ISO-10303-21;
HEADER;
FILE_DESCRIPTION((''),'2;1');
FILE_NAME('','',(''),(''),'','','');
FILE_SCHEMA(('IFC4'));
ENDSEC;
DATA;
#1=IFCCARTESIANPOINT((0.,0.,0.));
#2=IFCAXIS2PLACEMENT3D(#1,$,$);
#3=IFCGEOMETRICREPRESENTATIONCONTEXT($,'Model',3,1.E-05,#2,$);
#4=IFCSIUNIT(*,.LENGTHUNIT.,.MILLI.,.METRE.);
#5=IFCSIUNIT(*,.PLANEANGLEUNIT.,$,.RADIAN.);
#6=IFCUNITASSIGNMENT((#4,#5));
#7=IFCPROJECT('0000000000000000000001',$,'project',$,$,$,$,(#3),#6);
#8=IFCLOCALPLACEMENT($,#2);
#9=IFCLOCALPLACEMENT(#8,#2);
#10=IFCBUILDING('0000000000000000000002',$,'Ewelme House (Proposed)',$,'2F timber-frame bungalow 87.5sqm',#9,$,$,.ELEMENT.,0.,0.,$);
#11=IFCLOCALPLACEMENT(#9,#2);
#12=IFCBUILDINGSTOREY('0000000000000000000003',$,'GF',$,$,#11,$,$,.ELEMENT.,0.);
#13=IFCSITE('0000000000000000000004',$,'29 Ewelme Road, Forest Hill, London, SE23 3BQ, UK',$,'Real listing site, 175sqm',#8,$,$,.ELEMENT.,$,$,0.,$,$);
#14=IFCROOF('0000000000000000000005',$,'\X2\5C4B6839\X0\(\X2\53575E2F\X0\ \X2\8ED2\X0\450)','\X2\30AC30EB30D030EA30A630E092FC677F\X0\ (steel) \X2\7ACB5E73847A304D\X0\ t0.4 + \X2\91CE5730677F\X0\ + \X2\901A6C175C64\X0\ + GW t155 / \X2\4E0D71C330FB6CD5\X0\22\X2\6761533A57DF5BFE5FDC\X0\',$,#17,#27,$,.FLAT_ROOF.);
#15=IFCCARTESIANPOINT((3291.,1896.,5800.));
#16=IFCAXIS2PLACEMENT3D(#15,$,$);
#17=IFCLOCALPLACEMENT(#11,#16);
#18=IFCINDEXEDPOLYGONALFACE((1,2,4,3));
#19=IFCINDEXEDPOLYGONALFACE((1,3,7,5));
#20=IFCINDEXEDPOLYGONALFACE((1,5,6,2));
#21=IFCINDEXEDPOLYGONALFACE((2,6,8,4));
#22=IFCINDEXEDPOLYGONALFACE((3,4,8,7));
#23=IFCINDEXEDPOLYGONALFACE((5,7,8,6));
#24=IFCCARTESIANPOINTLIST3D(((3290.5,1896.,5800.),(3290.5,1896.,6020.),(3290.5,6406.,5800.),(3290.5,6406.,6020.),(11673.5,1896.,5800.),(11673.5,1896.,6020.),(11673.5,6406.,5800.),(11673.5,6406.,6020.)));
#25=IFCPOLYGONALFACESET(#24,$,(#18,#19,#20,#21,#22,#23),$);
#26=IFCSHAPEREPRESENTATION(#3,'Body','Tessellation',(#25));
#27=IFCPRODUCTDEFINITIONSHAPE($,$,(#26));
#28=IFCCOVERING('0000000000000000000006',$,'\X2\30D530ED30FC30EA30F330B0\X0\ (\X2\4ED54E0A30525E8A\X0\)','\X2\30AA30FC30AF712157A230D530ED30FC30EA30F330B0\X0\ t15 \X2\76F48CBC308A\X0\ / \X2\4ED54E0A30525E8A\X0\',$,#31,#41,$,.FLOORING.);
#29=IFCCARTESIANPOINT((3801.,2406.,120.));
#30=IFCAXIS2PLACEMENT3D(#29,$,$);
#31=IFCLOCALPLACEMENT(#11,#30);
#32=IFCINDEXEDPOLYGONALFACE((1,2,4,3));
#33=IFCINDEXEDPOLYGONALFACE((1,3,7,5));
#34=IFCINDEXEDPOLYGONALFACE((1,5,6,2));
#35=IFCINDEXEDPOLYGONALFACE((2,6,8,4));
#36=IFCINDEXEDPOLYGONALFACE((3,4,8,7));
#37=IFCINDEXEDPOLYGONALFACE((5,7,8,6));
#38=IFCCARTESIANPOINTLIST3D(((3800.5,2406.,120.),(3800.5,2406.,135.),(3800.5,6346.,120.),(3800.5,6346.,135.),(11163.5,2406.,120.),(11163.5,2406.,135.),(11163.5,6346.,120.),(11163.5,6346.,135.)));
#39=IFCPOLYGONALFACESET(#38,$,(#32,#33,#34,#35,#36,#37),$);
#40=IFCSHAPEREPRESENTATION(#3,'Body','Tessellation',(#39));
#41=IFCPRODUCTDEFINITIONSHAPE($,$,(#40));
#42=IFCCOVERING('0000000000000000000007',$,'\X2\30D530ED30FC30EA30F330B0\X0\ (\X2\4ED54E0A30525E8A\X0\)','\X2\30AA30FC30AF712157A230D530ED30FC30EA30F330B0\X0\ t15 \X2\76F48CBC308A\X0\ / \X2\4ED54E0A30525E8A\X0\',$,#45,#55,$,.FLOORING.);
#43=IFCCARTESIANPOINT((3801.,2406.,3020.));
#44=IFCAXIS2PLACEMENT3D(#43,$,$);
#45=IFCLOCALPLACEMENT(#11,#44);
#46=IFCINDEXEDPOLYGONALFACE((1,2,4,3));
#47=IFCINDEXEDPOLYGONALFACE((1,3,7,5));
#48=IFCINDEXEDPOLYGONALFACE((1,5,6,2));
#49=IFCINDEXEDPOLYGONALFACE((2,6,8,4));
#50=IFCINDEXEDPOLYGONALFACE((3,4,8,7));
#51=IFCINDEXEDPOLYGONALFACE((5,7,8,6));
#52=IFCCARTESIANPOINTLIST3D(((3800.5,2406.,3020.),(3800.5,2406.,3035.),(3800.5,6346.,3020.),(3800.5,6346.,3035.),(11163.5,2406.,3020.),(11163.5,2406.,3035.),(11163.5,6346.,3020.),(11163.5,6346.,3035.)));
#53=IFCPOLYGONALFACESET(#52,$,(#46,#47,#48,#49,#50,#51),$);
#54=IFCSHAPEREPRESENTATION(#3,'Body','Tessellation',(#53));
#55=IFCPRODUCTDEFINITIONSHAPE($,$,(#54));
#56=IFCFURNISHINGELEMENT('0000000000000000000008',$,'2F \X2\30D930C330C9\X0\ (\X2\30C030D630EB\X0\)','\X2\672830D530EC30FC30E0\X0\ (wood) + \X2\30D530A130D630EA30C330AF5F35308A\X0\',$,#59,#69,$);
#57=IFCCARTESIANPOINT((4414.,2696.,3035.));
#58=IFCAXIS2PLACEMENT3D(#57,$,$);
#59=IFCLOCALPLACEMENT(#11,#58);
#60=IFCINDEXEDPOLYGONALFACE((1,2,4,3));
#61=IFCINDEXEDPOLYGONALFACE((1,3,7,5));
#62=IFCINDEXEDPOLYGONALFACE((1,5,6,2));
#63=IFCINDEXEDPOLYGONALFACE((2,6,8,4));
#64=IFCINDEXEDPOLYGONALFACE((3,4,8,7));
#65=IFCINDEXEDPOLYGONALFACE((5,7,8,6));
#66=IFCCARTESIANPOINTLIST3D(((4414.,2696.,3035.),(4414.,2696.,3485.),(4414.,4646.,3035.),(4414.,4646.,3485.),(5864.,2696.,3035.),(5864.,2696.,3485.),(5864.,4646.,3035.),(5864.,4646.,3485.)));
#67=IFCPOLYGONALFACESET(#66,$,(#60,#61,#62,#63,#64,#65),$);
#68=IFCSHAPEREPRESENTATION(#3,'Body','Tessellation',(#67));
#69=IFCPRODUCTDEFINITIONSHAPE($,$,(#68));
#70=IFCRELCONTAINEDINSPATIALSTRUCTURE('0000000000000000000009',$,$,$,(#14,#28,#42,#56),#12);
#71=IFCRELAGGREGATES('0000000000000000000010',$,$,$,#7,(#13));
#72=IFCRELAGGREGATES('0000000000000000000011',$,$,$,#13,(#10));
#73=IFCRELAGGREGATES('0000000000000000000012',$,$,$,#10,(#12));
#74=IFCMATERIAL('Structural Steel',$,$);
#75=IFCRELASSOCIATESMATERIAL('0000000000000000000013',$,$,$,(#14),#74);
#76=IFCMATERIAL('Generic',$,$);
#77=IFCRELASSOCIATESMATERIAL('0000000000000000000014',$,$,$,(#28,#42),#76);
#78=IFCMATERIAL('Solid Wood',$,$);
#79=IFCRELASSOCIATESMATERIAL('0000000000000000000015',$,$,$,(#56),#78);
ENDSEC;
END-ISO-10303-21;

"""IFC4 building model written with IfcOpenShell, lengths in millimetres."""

from ifc_helpers import new_model, si_unit, frame, frame_2d, origin, place, context, project, spatial, rectangle, extrude, material, element, save


model = new_model("IFC4")

# Units and contexts
model_context = context("Model", 3, precision=1e-05, world=origin())
ifc_project = project(units=[si_unit("LENGTHUNIT", "METRE", prefix="MILLI"), si_unit("PLANEANGLEUNIT", "RADIAN")], contexts=[model_context])

# Site, building, storey
site_placement = place(None, origin())
site = spatial("IfcSite", under=ifc_project, at=site_placement, Name="29 Ewelme Road, Forest Hill, London, SE23 3BQ, UK", ObjectType="Real listing site, 175sqm", CompositionType="ELEMENT", RefElevation=0.0)
building_placement = place(site_placement, origin())
building = spatial("IfcBuilding", under=site, at=building_placement, Name="Ewelme House (Proposed)", ObjectType="2F timber-frame bungalow 87.5sqm", CompositionType="ELEMENT", ElevationOfRefHeight=0.0, ElevationOfTerrain=0.0)
storey_placement = place(building_placement, origin())
storey = spatial("IfcBuildingStorey", under=building, at=storey_placement, Name="GF", CompositionType="ELEMENT", Elevation=0.0)

# Shared definitions
ifc_material_1 = material(Name="Solid Wood")

# Roof
ifc_material_2 = material(Name="Structural Steel")
for number, where, name in (
    (1, (3291.0, 1896.0, 5800.0), "屋根(南帯 軒450)"),
):
    element("IfcRoof", number, at=place(storey_placement, frame(where)), inside=storey, material=ifc_material_2, Name=name, Description="ガルバリウム鋼板 (steel) 立平葺き t0.4 + 野地板 + 通気層 + GW t155 / 不燃・法22条区域対応", PredefinedType="FLAT_ROOF", context=model_context, shape_type="SweptSolid", body=[
        extrude(rectangle(XDim=8383.0, YDim=4510.0, at=frame_2d((4191.0, 2255.0))), frame((3291.0, 1896.0, 5800.0)), (0.0, 0.0, 1.0), 220.0),
    ])

# Coverings
ifc_material_3 = material(Name="Generic")
covering_1_placement = place(storey_placement, frame((3801.0, 2406.0, 120.0)))
element("IfcCovering", 2, at=covering_1_placement, inside=storey, material=ifc_material_3, Name="フローリング (仕上げ床)", Description="オーク無垢フローリング t15 直貼り / 仕上げ床", PredefinedType="FLOORING", context=model_context, shape_type="SweptSolid", body=[
    extrude(rectangle(XDim=7363.0, YDim=3940.0, at=frame_2d((3681.0, 1970.0))), frame((3801.0, 2406.0, 120.0)), (0.0, 0.0, 1.0), 15.0),
])
covering_2_placement = place(storey_placement, frame((3801.0, 2406.0, 3020.0)))
element("IfcCovering", 3, at=covering_2_placement, inside=storey, material=ifc_material_3, Name="フローリング (仕上げ床)", Description="オーク無垢フローリング t15 直貼り / 仕上げ床", PredefinedType="FLOORING", context=model_context, shape_type="SweptSolid", body=[
    extrude(rectangle(XDim=7363.0, YDim=3940.0, at=frame_2d((3681.0, 1970.0))), frame((3801.0, 2406.0, 3020.0)), (0.0, 0.0, 1.0), 15.0),
])

# Furnishing element
furnishing_placement = place(storey_placement, frame((4414.0, 2696.0, 3035.0)))
element("IfcFurnishingElement", 4, at=furnishing_placement, inside=storey, material=ifc_material_1, Name="2F ベッド (ダブル)", Description="木フレーム (wood) + ファブリック張り", context=model_context, shape_type="SweptSolid", body=[
    extrude(rectangle(XDim=1450.0, YDim=1950.0, at=frame_2d((725.0, 975.0))), frame((4414.0, 2696.0, 3035.0)), (0.0, 0.0, 1.0), 450.0),
])

save(model, "model.ifc")
